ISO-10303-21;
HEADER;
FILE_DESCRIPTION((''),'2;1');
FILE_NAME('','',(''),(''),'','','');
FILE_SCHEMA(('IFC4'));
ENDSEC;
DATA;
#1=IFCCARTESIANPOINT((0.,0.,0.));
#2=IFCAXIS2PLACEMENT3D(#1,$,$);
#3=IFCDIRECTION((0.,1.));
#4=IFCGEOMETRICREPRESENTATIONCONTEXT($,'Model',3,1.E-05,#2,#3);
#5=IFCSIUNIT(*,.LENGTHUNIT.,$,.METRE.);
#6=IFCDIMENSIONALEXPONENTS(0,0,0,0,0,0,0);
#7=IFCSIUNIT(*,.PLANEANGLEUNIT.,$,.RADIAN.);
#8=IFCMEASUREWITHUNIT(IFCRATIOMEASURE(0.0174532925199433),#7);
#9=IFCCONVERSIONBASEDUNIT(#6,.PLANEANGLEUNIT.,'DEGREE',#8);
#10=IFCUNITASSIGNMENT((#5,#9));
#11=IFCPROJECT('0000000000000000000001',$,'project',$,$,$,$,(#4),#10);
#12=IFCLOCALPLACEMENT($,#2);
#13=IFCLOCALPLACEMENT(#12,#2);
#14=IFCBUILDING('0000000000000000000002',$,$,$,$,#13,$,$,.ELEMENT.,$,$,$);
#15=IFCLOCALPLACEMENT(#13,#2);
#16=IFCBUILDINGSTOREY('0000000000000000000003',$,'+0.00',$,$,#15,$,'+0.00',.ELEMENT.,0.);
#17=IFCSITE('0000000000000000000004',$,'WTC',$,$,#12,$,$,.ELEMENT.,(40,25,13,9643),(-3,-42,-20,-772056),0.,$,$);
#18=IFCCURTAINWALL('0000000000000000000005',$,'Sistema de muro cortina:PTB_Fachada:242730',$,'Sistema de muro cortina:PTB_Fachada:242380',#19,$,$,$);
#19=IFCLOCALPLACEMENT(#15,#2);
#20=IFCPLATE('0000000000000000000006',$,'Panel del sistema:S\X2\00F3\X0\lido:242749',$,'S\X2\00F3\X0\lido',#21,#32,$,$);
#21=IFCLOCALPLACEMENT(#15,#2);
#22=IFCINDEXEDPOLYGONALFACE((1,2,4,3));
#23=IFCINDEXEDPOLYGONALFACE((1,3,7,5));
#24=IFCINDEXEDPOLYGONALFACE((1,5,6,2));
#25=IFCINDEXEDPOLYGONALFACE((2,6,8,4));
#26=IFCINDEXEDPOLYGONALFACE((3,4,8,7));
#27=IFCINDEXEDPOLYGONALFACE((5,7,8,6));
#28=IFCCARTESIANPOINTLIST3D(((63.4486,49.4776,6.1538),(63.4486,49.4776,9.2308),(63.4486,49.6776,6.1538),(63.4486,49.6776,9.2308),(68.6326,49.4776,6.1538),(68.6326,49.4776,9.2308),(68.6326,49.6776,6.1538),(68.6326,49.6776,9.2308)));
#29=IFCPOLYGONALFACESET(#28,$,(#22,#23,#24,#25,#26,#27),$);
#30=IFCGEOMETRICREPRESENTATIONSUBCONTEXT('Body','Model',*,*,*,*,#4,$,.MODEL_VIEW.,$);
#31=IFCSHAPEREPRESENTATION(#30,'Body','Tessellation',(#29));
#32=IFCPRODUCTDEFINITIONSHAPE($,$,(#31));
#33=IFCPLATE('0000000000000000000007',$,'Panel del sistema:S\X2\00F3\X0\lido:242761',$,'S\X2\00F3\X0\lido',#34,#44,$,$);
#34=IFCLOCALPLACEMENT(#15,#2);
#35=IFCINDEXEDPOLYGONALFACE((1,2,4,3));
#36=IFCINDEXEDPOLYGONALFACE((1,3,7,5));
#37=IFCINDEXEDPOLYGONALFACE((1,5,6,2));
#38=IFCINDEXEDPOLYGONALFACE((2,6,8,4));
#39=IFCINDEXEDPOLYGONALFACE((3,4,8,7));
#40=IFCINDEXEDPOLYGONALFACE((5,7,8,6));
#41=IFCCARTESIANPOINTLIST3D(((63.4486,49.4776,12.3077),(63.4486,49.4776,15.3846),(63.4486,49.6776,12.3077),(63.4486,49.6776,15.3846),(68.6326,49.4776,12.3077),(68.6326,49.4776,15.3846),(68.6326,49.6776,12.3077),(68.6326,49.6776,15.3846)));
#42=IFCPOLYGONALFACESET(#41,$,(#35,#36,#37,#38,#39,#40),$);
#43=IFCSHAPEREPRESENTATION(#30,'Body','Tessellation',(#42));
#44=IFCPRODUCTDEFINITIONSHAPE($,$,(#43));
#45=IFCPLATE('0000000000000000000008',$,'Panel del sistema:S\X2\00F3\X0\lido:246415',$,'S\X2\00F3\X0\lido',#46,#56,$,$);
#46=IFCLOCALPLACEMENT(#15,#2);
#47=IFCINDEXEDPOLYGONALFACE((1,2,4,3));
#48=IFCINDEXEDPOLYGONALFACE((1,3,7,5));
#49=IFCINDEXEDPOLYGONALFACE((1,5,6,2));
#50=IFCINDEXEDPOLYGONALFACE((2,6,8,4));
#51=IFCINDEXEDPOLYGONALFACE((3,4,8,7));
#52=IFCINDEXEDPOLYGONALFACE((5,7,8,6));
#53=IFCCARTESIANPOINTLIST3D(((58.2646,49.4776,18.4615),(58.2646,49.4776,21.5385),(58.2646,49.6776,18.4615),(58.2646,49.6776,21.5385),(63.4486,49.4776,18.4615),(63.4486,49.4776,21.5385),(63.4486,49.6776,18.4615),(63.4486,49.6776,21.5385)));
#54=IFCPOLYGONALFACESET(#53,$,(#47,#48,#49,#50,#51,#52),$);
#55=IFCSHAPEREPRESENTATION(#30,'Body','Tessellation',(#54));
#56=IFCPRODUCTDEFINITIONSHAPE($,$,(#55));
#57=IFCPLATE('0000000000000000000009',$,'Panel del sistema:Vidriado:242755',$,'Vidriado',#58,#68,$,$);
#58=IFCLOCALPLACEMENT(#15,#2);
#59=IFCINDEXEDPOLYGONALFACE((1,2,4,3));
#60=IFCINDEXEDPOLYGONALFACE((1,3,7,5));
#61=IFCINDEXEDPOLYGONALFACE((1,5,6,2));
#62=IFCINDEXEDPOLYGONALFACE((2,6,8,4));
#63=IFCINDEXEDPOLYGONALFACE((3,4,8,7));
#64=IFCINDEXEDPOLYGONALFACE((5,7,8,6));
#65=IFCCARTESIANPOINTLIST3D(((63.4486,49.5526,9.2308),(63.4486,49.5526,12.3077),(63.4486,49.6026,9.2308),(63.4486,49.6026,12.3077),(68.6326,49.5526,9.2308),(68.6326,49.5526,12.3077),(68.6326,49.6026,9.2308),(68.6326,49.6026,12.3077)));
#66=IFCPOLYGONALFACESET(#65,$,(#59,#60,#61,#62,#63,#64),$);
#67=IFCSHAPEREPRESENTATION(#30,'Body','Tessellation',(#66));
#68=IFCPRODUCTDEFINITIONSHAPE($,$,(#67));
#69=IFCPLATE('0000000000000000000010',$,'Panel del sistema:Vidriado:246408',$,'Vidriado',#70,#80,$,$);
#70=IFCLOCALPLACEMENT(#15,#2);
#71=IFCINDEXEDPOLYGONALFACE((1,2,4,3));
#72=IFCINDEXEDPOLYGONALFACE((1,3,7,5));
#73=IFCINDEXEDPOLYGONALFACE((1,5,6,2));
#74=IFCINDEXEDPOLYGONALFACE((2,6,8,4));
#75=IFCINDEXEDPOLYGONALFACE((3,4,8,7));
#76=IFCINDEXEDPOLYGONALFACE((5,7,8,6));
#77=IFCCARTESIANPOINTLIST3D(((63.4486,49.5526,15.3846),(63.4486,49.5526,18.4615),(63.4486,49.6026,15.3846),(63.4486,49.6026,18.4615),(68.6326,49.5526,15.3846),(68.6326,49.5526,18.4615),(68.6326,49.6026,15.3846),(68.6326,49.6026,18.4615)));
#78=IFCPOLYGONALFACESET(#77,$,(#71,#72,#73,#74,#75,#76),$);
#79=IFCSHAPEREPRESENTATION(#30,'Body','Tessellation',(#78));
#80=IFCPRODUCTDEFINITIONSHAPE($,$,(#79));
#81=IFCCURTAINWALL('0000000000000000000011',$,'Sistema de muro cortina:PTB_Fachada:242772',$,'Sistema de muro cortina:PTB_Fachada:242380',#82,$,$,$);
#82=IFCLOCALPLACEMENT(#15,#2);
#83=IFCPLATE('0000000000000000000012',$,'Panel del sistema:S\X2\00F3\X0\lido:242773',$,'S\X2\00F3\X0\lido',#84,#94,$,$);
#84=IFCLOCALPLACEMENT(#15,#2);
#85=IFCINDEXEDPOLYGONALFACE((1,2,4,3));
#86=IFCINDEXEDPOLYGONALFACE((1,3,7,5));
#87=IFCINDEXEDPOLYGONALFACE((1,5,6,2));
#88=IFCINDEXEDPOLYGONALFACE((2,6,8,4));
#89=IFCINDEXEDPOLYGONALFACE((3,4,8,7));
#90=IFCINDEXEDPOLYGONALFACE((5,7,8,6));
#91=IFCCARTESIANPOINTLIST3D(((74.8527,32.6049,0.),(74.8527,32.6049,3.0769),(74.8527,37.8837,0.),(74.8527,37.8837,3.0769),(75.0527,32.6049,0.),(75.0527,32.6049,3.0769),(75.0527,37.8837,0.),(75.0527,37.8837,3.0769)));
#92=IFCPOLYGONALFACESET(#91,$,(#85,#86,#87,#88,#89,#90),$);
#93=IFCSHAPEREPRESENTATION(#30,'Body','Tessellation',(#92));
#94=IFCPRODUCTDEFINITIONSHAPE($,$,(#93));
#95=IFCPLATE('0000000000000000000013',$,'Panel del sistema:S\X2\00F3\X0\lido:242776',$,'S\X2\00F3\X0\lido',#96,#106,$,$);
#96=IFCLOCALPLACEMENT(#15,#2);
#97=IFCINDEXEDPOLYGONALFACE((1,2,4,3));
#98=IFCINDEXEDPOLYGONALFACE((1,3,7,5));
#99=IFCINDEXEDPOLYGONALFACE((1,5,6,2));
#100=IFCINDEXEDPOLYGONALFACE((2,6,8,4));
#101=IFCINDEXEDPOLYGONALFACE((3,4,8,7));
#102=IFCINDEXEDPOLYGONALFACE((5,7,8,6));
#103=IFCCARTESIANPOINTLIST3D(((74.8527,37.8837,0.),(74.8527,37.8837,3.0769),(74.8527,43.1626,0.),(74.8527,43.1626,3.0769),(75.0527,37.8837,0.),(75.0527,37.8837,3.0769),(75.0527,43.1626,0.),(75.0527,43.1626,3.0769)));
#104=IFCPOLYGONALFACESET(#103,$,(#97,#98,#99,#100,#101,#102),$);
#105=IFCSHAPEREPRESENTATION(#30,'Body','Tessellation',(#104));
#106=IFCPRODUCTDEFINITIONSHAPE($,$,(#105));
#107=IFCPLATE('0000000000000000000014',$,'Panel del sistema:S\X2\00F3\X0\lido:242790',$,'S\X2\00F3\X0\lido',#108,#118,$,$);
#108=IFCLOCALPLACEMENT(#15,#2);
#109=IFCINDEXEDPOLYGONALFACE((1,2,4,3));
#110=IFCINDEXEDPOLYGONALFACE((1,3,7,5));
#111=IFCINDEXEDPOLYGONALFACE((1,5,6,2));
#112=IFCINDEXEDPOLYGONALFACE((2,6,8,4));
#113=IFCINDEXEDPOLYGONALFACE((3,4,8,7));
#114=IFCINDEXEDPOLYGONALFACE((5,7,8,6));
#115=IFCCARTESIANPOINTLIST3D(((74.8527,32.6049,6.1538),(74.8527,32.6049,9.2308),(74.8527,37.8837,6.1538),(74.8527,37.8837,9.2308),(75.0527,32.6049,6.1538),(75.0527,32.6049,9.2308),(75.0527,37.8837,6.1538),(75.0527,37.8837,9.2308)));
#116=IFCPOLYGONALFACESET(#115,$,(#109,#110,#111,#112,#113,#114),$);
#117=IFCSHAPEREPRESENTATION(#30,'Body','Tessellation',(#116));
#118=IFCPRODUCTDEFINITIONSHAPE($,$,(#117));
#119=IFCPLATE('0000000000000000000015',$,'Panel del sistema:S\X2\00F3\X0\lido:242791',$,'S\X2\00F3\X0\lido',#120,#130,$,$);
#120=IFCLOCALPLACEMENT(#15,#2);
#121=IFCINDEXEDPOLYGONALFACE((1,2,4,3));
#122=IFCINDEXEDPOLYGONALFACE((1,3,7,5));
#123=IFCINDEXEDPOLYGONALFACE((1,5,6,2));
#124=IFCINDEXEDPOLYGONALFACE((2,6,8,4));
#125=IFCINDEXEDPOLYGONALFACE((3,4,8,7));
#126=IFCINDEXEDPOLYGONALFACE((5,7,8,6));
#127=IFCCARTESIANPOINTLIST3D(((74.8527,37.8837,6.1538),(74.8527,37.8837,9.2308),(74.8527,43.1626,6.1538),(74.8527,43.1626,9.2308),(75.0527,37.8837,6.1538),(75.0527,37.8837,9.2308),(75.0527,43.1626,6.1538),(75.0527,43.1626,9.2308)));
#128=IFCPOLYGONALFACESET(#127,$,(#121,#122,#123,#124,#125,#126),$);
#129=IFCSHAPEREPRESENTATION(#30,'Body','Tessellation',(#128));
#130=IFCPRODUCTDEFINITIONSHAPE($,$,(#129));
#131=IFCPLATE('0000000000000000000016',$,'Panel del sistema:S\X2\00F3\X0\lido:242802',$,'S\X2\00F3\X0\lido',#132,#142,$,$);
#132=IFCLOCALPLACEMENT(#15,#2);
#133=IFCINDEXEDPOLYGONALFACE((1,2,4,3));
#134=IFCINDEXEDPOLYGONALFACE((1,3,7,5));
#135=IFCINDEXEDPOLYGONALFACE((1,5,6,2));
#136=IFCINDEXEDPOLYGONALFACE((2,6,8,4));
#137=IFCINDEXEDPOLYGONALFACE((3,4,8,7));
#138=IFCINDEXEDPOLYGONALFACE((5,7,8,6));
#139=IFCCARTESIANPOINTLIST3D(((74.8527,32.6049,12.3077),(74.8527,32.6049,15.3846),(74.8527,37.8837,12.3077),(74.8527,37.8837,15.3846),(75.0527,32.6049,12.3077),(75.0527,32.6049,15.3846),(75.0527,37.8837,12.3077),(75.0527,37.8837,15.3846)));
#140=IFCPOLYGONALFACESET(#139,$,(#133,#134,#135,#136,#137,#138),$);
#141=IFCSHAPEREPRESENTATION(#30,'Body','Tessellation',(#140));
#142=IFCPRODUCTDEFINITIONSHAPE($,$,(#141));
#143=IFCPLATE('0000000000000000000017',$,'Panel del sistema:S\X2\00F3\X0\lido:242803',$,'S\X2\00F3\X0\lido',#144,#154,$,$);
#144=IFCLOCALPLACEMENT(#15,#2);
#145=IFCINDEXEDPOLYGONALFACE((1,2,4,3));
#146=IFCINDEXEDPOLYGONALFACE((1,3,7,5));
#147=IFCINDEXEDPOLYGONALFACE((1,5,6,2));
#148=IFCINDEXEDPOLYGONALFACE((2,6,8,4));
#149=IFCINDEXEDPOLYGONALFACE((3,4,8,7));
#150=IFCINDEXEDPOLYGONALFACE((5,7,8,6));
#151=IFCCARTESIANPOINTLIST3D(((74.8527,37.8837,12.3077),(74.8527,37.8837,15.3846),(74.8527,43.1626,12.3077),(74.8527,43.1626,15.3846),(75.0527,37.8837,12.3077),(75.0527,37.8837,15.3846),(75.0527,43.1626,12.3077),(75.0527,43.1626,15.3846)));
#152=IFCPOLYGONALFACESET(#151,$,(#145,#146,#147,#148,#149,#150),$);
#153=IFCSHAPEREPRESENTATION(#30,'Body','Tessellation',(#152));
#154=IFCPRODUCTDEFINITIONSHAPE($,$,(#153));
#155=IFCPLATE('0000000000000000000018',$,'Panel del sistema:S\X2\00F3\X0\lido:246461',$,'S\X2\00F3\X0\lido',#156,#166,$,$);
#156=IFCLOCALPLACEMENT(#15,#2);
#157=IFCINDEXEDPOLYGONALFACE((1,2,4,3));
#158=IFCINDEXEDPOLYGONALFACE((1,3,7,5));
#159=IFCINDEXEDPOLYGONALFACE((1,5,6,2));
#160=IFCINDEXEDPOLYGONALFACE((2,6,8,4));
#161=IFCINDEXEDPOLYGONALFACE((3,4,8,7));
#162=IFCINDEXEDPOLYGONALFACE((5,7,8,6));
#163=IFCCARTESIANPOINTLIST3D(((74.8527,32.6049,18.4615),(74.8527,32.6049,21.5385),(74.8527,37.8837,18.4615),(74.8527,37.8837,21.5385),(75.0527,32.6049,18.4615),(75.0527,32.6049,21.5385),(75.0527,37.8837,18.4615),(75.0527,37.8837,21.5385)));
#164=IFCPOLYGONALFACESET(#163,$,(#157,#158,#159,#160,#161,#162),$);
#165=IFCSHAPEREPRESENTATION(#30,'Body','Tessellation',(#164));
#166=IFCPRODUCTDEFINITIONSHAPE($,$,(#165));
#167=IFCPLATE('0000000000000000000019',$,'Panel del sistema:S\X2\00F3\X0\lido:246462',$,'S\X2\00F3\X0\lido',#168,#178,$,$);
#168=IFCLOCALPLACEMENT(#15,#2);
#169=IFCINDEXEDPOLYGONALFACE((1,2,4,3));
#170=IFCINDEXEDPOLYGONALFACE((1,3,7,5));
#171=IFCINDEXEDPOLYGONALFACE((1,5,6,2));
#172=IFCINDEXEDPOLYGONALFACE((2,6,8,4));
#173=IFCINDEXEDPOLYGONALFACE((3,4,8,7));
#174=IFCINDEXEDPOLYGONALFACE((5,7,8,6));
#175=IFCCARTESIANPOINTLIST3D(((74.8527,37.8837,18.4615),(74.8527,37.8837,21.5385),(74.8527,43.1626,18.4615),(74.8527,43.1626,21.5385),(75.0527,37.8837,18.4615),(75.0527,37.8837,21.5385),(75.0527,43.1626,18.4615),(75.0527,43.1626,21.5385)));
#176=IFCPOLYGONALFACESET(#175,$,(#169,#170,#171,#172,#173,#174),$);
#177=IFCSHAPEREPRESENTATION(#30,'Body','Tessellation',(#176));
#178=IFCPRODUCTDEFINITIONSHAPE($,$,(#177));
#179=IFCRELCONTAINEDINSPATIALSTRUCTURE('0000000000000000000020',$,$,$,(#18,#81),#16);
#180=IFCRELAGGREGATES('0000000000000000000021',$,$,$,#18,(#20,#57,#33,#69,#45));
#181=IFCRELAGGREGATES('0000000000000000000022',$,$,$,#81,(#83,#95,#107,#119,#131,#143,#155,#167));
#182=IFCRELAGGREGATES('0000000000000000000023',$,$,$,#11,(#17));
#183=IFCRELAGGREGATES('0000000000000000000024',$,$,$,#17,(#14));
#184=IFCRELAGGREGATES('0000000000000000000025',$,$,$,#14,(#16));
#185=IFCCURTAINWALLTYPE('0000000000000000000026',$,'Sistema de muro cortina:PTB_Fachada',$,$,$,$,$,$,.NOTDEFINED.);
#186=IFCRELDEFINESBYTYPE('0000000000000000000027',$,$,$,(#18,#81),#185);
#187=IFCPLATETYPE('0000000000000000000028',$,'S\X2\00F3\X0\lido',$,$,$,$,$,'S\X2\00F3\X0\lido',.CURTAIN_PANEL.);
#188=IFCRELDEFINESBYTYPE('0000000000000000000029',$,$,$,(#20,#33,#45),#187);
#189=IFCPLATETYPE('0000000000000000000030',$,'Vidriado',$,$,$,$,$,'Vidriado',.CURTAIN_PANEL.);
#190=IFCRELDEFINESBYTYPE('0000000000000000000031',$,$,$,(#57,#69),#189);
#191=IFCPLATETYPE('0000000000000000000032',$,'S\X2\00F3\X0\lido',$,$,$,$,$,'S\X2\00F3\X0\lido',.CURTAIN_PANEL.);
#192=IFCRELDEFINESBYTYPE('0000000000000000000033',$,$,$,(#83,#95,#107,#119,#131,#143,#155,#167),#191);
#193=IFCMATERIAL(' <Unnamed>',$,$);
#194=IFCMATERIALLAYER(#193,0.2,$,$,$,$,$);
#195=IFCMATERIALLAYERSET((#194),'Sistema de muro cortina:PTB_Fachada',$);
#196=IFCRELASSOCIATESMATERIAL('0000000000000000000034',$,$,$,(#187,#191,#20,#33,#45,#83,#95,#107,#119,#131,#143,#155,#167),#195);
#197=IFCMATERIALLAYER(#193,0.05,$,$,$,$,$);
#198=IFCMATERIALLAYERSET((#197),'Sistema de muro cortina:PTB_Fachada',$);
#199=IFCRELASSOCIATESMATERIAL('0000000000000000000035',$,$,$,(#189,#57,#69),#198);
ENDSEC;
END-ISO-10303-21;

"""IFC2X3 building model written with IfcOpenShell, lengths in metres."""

from ifc_helpers import new_model, entity, si_unit, converted_unit, direction, frame, frame_2d, origin, origin_2d_with_axis, place, context, subcontext, project, spatial, rectangle, extrude, source, transform, mapped, material, layer, layer_set, layer_usage, type_object, type_shapes, element, aggregate, save


model = new_model("IFC2X3")

# Units and contexts
model_context = context("Model", 3, precision=1e-05, world=origin(), true_north=direction((0.0, 1.0)))
body_context = subcontext(model_context, "Body", "Model", "MODEL_VIEW")
ifc_project = project(units=[si_unit("LENGTHUNIT", "METRE"), converted_unit("PLANEANGLEUNIT", "DEGREE", entity("IfcRatioMeasure", 0.0174532925199433), si_unit("PLANEANGLEUNIT", "RADIAN"), dimensions=[0, 0, 0, 0, 0, 0, 0])], contexts=[model_context])

# Site, building, storey
site_placement = place(None, origin())
site = spatial("IfcSite", under=ifc_project, at=site_placement, Name="WTC", CompositionType="ELEMENT", RefLatitude=(40, 25, 13, 9643), RefLongitude=(-3, -42, -20, -772056), RefElevation=0.0)
building_placement = place(site_placement, origin())
building = spatial("IfcBuilding", under=site, at=building_placement, CompositionType="ELEMENT")
storey_placement = place(building_placement, origin())
storey = spatial("IfcBuildingStorey", under=building, at=storey_placement, Name="+0.00", LongName="+0.00", CompositionType="ELEMENT", Elevation=0.0)

# Curtain walls, plates
curtain_wall_type = type_object("IfcCurtainWallType", Name="Sistema de muro cortina:PTB_Fachada", PredefinedType="NOTDEFINED")
ifc_material = material(Name=" <Unnamed>")
ifc_layer_1 = layer(ifc_material, 0.2)
ifc_layer_set_1 = layer_set([ifc_layer_1], Name="Sistema de muro cortina:PTB_Fachada")
ifc_layer_2 = layer(ifc_material, 0.05)
ifc_layer_set_2 = layer_set([ifc_layer_2], Name="Sistema de muro cortina:PTB_Fachada")
curtain_wall_1_placement = place(storey_placement, origin())
curtain_wall_1 = element("IfcCurtainWall", 1, at=curtain_wall_1_placement, inside=storey, type_object=curtain_wall_type, Name="Sistema de muro cortina:PTB_Fachada:242730", ObjectType="Sistema de muro cortina:PTB_Fachada:242380")
ifc_layer_usage_1 = layer_usage(ifc_layer_set_1, "AXIS3", "POSITIVE", 0.0)
plate_type_1 = type_object("IfcPlateType", Name="Sólido", ElementType="Sólido", PredefinedType="CURTAIN_PANEL", material=ifc_layer_set_1)
shared_shape_1 = source(origin(), body_context, "Body", "SweptSolid", [
    extrude(rectangle(XDim=0.2, YDim=5.184, at=origin_2d_with_axis()), frame((0.0, 0.0, 0.0), z_axis=(0.0, 0.0, 1.0), x_axis=(0.0, 1.0, 0.0)), (0.0, 0.0, 1.0), 3.0769),
])
type_shapes(plate_type_1, [shared_shape_1])
plate_1_placement = place(curtain_wall_1_placement, frame((66.0406, 49.5776, 6.1538), z_axis=(0.0, 0.0, 1.0), x_axis=(-1.0, 0.0, 0.0)))
plate_1 = element("IfcPlate", 2, at=plate_1_placement, type_object=plate_type_1, material=ifc_layer_usage_1, Name="Panel del sistema:Sólido:242749", ObjectType="Sólido", context=body_context, shape_type="MappedRepresentation", body=[
    mapped(shared_shape_1, transform((0.0, 0.0, 0.0), scale=1.0)),
])
ifc_layer_usage_2 = layer_usage(ifc_layer_set_1, "AXIS3", "POSITIVE", 0.0)
plate_2_placement = place(curtain_wall_1_placement, frame((66.0406, 49.5776, 12.3077), z_axis=(0.0, 0.0, 1.0), x_axis=(-1.0, 0.0, 0.0)))
plate_2 = element("IfcPlate", 3, at=plate_2_placement, type_object=plate_type_1, material=ifc_layer_usage_2, Name="Panel del sistema:Sólido:242761", ObjectType="Sólido", context=body_context, shape_type="MappedRepresentation", body=[
    mapped(shared_shape_1, transform((0.0, 0.0, 0.0), scale=1.0)),
])
ifc_layer_usage_3 = layer_usage(ifc_layer_set_1, "AXIS3", "POSITIVE", 0.0)
plate_3_placement = place(curtain_wall_1_placement, frame((60.8566, 49.5776, 18.4615), z_axis=(0.0, 0.0, 1.0), x_axis=(-1.0, 0.0, 0.0)))
plate_3 = element("IfcPlate", 4, at=plate_3_placement, type_object=plate_type_1, material=ifc_layer_usage_3, Name="Panel del sistema:Sólido:246415", ObjectType="Sólido", context=body_context, shape_type="MappedRepresentation", body=[
    mapped(shared_shape_1, transform((0.0, 0.0, 0.0), scale=1.0)),
])
ifc_layer_usage_4 = layer_usage(ifc_layer_set_2, "AXIS3", "POSITIVE", 0.0)
plate_type_2 = type_object("IfcPlateType", Name="Vidriado", ElementType="Vidriado", PredefinedType="CURTAIN_PANEL", material=ifc_layer_set_2)
shared_shape_2 = source(origin(), body_context, "Body", "SweptSolid", [
    extrude(rectangle(XDim=0.05, YDim=5.184, at=origin_2d_with_axis()), frame((0.0, 0.0, 0.0), z_axis=(0.0, 0.0, 1.0), x_axis=(0.0, 1.0, 0.0)), (0.0, 0.0, 1.0), 3.0769),
])
type_shapes(plate_type_2, [shared_shape_2])
plate_4_placement = place(curtain_wall_1_placement, frame((66.0406, 49.5776, 9.2308), z_axis=(0.0, 0.0, 1.0), x_axis=(-1.0, 0.0, 0.0)))
plate_4 = element("IfcPlate", 5, at=plate_4_placement, type_object=plate_type_2, material=ifc_layer_usage_4, Name="Panel del sistema:Vidriado:242755", ObjectType="Vidriado", context=body_context, shape_type="MappedRepresentation", body=[
    mapped(shared_shape_2, transform((0.0, 0.0, 0.0), scale=1.0)),
])
ifc_layer_usage_5 = layer_usage(ifc_layer_set_2, "AXIS3", "POSITIVE", 0.0)
plate_5_placement = place(curtain_wall_1_placement, frame((66.0406, 49.5776, 15.3846), z_axis=(0.0, 0.0, 1.0), x_axis=(-1.0, 0.0, 0.0)))
plate_5 = element("IfcPlate", 6, at=plate_5_placement, type_object=plate_type_2, material=ifc_layer_usage_5, Name="Panel del sistema:Vidriado:246408", ObjectType="Vidriado", context=body_context, shape_type="MappedRepresentation", body=[
    mapped(shared_shape_2, transform((0.0, 0.0, 0.0), scale=1.0)),
])
aggregate(curtain_wall_1, [plate_1, plate_4, plate_2, plate_5, plate_3])
curtain_wall_2_placement = place(storey_placement, origin())
curtain_wall_2 = element("IfcCurtainWall", 7, at=curtain_wall_2_placement, inside=storey, type_object=curtain_wall_type, Name="Sistema de muro cortina:PTB_Fachada:242772", ObjectType="Sistema de muro cortina:PTB_Fachada:242380")
ifc_layer_usage_6 = layer_usage(ifc_layer_set_1, "AXIS3", "POSITIVE", 0.0)
plate_type_3 = type_object("IfcPlateType", Name="Sólido", ElementType="Sólido", PredefinedType="CURTAIN_PANEL", material=ifc_layer_set_1)
shared_shape_3 = source(origin(), body_context, "Body", "SweptSolid", [
    extrude(rectangle(XDim=0.2, YDim=5.2789, at=frame_2d((0.0, 0.0), x_axis=(1.0, 0.0))), frame((0.0, 0.0, 0.0), z_axis=(0.0, 0.0, 1.0), x_axis=(0.0, 1.0, 0.0)), (0.0, 0.0, 1.0), 3.0769),
])
type_shapes(plate_type_3, [shared_shape_3])
plate_6_placement = place(curtain_wall_2_placement, frame((74.9527, 35.2443, 0.0), z_axis=(0.0, 0.0, 1.0), x_axis=(0.0, 1.0, 0.0)))
plate_6 = element("IfcPlate", 8, at=plate_6_placement, type_object=plate_type_3, material=ifc_layer_usage_6, Name="Panel del sistema:Sólido:242773", ObjectType="Sólido", context=body_context, shape_type="MappedRepresentation", body=[
    mapped(shared_shape_3, transform((0.0, 0.0, 0.0), scale=1.0)),
])
ifc_layer_usage_7 = layer_usage(ifc_layer_set_1, "AXIS3", "POSITIVE", 0.0)
plate_7_placement = place(curtain_wall_2_placement, frame((74.9527, 40.5232, 0.0), z_axis=(0.0, 0.0, 1.0), x_axis=(0.0, 1.0, 0.0)))
plate_7 = element("IfcPlate", 9, at=plate_7_placement, type_object=plate_type_3, material=ifc_layer_usage_7, Name="Panel del sistema:Sólido:242776", ObjectType="Sólido", context=body_context, shape_type="MappedRepresentation", body=[
    mapped(shared_shape_3, transform((0.0, 0.0, 0.0), scale=1.0)),
])
ifc_layer_usage_8 = layer_usage(ifc_layer_set_1, "AXIS3", "POSITIVE", 0.0)
plate_8_placement = place(curtain_wall_2_placement, frame((74.9527, 35.2443, 6.1538), z_axis=(0.0, 0.0, 1.0), x_axis=(0.0, 1.0, 0.0)))
plate_8 = element("IfcPlate", 10, at=plate_8_placement, type_object=plate_type_3, material=ifc_layer_usage_8, Name="Panel del sistema:Sólido:242790", ObjectType="Sólido", context=body_context, shape_type="MappedRepresentation", body=[
    mapped(shared_shape_3, transform((0.0, 0.0, 0.0), scale=1.0)),
])
ifc_layer_usage_9 = layer_usage(ifc_layer_set_1, "AXIS3", "POSITIVE", 0.0)
plate_9_placement = place(curtain_wall_2_placement, frame((74.9527, 40.5232, 6.1538), z_axis=(0.0, 0.0, 1.0), x_axis=(0.0, 1.0, 0.0)))
plate_9 = element("IfcPlate", 11, at=plate_9_placement, type_object=plate_type_3, material=ifc_layer_usage_9, Name="Panel del sistema:Sólido:242791", ObjectType="Sólido", context=body_context, shape_type="MappedRepresentation", body=[
    mapped(shared_shape_3, transform((0.0, 0.0, 0.0), scale=1.0)),
])
ifc_layer_usage_10 = layer_usage(ifc_layer_set_1, "AXIS3", "POSITIVE", 0.0)
plate_10_placement = place(curtain_wall_2_placement, frame((74.9527, 35.2443, 12.3077), z_axis=(0.0, 0.0, 1.0), x_axis=(0.0, 1.0, 0.0)))
plate_10 = element("IfcPlate", 12, at=plate_10_placement, type_object=plate_type_3, material=ifc_layer_usage_10, Name="Panel del sistema:Sólido:242802", ObjectType="Sólido", context=body_context, shape_type="MappedRepresentation", body=[
    mapped(shared_shape_3, transform((0.0, 0.0, 0.0), scale=1.0)),
])
ifc_layer_usage_11 = layer_usage(ifc_layer_set_1, "AXIS3", "POSITIVE", 0.0)
plate_11_placement = place(curtain_wall_2_placement, frame((74.9527, 40.5232, 12.3077), z_axis=(0.0, 0.0, 1.0), x_axis=(0.0, 1.0, 0.0)))
plate_11 = element("IfcPlate", 13, at=plate_11_placement, type_object=plate_type_3, material=ifc_layer_usage_11, Name="Panel del sistema:Sólido:242803", ObjectType="Sólido", context=body_context, shape_type="MappedRepresentation", body=[
    mapped(shared_shape_3, transform((0.0, 0.0, 0.0), scale=1.0)),
])
ifc_layer_usage_12 = layer_usage(ifc_layer_set_1, "AXIS3", "POSITIVE", 0.0)
plate_12_placement = place(curtain_wall_2_placement, frame((74.9527, 35.2443, 18.4615), z_axis=(0.0, 0.0, 1.0), x_axis=(0.0, 1.0, 0.0)))
plate_12 = element("IfcPlate", 14, at=plate_12_placement, type_object=plate_type_3, material=ifc_layer_usage_12, Name="Panel del sistema:Sólido:246461", ObjectType="Sólido", context=body_context, shape_type="MappedRepresentation", body=[
    mapped(shared_shape_3, transform((0.0, 0.0, 0.0), scale=1.0)),
])
ifc_layer_usage_13 = layer_usage(ifc_layer_set_1, "AXIS3", "POSITIVE", 0.0)
plate_13_placement = place(curtain_wall_2_placement, frame((74.9527, 40.5232, 18.4615), z_axis=(0.0, 0.0, 1.0), x_axis=(0.0, 1.0, 0.0)))
plate_13 = element("IfcPlate", 15, at=plate_13_placement, type_object=plate_type_3, material=ifc_layer_usage_13, Name="Panel del sistema:Sólido:246462", ObjectType="Sólido", context=body_context, shape_type="MappedRepresentation", body=[
    mapped(shared_shape_3, transform((0.0, 0.0, 0.0), scale=1.0)),
])
aggregate(curtain_wall_2, [plate_6, plate_7, plate_8, plate_9, plate_10, plate_11, plate_12, plate_13])

save(model, "model.ifc")
